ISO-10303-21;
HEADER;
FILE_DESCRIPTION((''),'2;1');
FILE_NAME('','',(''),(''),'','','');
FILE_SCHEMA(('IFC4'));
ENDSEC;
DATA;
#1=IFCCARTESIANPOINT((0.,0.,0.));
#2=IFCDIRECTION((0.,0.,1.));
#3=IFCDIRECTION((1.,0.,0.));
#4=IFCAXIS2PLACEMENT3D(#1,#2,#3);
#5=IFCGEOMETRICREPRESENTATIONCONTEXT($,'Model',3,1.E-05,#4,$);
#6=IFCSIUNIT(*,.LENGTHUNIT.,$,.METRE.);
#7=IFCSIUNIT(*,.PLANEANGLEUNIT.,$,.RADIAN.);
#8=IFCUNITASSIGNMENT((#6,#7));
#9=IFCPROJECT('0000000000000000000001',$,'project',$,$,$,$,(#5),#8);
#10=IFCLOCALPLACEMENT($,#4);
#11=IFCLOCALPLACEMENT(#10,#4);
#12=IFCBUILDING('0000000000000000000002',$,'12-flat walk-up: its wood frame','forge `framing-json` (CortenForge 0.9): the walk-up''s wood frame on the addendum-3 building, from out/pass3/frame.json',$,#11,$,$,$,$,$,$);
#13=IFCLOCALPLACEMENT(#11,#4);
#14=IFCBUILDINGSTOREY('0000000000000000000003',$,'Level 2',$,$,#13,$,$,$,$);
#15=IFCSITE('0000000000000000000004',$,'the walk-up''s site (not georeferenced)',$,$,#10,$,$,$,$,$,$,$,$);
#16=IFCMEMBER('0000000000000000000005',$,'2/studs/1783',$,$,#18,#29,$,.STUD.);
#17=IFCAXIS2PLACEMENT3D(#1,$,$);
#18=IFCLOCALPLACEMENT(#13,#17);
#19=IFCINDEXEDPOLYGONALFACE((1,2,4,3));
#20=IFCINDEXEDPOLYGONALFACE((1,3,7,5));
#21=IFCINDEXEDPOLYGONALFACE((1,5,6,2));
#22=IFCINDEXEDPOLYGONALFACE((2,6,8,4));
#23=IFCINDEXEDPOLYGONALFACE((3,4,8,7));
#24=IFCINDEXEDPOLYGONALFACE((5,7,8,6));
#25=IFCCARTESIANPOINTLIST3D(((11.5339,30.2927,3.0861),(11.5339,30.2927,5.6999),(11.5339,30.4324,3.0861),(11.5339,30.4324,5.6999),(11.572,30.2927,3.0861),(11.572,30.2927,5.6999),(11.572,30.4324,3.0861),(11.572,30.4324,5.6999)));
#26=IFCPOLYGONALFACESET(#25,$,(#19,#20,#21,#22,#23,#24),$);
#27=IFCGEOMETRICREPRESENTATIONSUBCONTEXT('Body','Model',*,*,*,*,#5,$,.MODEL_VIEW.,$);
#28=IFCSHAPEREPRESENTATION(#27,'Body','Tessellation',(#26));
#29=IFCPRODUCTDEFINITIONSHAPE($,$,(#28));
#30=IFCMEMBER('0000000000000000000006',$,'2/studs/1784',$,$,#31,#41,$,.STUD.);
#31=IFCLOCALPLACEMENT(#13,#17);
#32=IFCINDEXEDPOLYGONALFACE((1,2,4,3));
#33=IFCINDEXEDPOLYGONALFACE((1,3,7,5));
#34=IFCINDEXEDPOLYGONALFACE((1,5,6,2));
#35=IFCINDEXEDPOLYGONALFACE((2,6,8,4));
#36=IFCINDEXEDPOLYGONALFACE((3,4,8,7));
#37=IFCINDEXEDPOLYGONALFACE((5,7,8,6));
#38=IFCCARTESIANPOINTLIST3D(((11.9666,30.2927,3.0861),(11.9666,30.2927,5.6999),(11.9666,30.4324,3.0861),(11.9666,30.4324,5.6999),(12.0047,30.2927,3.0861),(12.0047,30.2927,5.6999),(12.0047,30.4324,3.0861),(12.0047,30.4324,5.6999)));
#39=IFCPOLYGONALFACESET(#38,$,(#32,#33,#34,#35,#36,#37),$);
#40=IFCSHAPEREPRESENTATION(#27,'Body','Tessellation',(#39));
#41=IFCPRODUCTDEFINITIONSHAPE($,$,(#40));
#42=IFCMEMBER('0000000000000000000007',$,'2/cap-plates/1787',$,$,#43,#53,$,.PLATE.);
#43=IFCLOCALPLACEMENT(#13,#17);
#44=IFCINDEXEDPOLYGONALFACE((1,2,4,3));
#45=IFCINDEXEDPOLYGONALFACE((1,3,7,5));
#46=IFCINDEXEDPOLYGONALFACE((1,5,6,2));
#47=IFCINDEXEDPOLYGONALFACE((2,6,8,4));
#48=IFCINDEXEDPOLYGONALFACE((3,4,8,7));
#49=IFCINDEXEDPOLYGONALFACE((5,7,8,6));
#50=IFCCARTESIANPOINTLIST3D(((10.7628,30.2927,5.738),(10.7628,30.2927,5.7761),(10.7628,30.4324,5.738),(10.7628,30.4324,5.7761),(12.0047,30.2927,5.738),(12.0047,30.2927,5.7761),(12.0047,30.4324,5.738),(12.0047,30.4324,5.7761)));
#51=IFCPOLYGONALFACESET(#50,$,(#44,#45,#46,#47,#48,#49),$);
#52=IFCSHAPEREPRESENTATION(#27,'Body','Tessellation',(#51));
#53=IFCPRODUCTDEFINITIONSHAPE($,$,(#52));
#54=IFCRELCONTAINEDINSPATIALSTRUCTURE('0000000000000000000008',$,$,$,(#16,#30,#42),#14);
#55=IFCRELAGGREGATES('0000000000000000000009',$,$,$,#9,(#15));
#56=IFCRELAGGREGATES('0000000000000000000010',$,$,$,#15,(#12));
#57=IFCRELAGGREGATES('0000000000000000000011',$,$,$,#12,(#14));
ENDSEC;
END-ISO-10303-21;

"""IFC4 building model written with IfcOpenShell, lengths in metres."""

from ifc_helpers import new_model, si_unit, frame, frame_2d, origin, origin_with_axes, place, context, subcontext, project, spatial, rectangle, extrude, element, save


model = new_model("IFC4")

# Units and contexts
model_context = context("Model", 3, precision=1e-05, world=origin_with_axes())
body_context = subcontext(model_context, "Body", "Model", "MODEL_VIEW")
ifc_project = project(units=[si_unit("LENGTHUNIT", "METRE"), si_unit("PLANEANGLEUNIT", "RADIAN")], contexts=[model_context])

# Site, building, storey
site_placement = place(None, origin_with_axes())
site = spatial("IfcSite", under=ifc_project, at=site_placement, Name="the walk-up's site (not georeferenced)")
building_placement = place(site_placement, origin_with_axes())
building = spatial("IfcBuilding", under=site, at=building_placement, Name="12-flat walk-up: its wood frame", Description="forge `framing-json` (CortenForge 0.9): the walk-up's wood frame on the addendum-3 building, from out/pass3/frame.json")
storey_placement = place(building_placement, origin_with_axes())
storey = spatial("IfcBuildingStorey", under=building, at=storey_placement, Name="Level 2")

# Members
for number, where, z_axis, x_axis, name in (
    (1, (11.5339, 30.2927, 3.0861), (0.0, 0.0, 1.0), (1.0, 0.0, 0.0), "2/studs/1783"),
    (2, (11.9666, 30.2927, 3.0861), (0.0, 0.0, 1.0), (1.0, 0.0, 0.0), "2/studs/1784"),
):
    element("IfcMember", number, at=place(storey_placement, frame(where, z_axis=z_axis, x_axis=x_axis)), inside=storey, Name=name, PredefinedType="STUD", context=body_context, shape_type="SweptSolid", body=[
        extrude(rectangle(XDim=0.0381, YDim=0.1397, at=frame_2d((0.0191, 0.0699))), origin(), (0.0, 0.0, 1.0), 2.6138),
    ])
member_1_placement = place(storey_placement, frame((10.7628, 30.2927, 5.738), z_axis=(0.0, 0.0, 1.0), x_axis=(1.0, 0.0, 0.0)))
element("IfcMember", 3, at=member_1_placement, inside=storey, Name="2/cap-plates/1787", PredefinedType="PLATE", context=body_context, shape_type="SweptSolid", body=[
    extrude(rectangle(XDim=1.2419, YDim=0.1397, at=frame_2d((0.6209, 0.0699))), origin(), (0.0, 0.0, 1.0), 0.0381),
])

save(model, "model.ifc")
